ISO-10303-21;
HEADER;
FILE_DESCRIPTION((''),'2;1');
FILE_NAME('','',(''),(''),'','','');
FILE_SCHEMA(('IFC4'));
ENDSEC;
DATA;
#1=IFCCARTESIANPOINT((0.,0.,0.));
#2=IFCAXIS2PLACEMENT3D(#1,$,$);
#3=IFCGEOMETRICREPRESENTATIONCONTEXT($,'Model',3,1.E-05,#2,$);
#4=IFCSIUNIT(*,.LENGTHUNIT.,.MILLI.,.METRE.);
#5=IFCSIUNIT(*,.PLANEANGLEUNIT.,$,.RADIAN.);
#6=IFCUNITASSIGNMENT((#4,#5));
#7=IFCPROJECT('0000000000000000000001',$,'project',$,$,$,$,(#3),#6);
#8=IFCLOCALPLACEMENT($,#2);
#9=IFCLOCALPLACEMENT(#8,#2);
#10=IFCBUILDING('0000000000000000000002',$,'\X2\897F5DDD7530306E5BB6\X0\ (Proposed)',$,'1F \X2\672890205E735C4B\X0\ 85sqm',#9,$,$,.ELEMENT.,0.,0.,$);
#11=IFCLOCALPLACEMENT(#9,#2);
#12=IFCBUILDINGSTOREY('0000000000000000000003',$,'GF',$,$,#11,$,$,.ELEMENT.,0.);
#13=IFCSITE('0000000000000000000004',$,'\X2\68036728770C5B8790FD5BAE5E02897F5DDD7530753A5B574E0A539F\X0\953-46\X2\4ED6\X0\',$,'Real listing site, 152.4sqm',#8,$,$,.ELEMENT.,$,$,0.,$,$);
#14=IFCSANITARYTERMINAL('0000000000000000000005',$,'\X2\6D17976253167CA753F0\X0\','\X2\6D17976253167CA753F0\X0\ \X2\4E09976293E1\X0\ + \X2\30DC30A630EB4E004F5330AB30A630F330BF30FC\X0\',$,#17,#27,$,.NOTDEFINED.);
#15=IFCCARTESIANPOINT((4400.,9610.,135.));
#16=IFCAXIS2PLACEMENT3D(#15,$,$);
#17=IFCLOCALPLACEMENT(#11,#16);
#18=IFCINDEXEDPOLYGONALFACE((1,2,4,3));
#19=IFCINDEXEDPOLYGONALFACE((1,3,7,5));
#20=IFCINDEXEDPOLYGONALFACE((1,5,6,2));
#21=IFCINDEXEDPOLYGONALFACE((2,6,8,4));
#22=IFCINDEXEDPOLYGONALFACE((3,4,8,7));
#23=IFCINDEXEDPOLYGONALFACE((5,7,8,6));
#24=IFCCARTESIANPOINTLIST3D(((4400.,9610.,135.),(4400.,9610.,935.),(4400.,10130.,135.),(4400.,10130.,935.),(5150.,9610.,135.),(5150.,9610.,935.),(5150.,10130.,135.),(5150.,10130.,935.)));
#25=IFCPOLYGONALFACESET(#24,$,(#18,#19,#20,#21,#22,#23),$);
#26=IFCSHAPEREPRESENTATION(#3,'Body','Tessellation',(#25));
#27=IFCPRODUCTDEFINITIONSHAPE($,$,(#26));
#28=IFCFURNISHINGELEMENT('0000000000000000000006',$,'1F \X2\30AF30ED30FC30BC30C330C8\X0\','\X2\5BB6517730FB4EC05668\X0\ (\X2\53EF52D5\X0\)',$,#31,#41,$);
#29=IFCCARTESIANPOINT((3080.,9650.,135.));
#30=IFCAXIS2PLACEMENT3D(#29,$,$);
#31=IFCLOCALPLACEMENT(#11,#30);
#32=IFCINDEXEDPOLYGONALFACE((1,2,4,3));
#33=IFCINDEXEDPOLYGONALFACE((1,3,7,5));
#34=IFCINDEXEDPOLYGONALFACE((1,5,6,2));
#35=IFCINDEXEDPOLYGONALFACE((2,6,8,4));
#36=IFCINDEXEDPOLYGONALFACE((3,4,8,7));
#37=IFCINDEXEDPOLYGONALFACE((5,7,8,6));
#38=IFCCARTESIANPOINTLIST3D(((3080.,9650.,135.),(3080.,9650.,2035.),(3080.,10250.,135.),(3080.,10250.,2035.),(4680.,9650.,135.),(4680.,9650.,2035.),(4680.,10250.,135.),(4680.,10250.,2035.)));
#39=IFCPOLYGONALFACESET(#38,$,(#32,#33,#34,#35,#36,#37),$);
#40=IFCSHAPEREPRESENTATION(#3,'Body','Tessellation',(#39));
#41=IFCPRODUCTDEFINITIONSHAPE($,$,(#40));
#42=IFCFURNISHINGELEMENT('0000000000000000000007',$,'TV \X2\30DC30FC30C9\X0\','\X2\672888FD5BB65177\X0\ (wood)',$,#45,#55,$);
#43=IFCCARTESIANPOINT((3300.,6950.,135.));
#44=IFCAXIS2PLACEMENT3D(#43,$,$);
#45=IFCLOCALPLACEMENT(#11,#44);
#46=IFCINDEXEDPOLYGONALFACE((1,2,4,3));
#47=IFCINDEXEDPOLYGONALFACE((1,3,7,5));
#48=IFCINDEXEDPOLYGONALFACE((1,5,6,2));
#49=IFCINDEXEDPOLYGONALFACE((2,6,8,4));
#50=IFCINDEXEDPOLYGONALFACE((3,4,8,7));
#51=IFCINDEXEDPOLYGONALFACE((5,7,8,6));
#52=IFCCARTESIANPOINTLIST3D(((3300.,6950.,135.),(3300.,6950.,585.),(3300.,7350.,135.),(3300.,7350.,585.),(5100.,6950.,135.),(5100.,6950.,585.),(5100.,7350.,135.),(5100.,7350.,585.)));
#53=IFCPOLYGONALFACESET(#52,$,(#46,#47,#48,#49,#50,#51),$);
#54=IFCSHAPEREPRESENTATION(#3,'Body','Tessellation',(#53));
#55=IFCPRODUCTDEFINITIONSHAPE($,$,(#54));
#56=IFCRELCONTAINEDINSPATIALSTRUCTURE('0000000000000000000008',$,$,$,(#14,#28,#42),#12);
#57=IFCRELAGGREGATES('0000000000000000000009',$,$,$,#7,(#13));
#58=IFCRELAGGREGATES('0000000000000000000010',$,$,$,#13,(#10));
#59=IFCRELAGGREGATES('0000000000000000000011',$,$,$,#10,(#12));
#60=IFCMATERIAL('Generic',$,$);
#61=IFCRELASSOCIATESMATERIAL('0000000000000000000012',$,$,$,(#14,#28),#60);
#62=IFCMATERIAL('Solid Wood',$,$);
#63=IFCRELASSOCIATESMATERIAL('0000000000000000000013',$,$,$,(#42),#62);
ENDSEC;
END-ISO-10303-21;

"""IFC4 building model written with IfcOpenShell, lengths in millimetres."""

from ifc_helpers import new_model, si_unit, frame, frame_2d, origin, place, context, project, spatial, rectangle, extrude, material, element, save


model = new_model("IFC4")

# Units and contexts
model_context = context("Model", 3, precision=1e-05, world=origin())
ifc_project = project(units=[si_unit("LENGTHUNIT", "METRE", prefix="MILLI"), si_unit("PLANEANGLEUNIT", "RADIAN")], contexts=[model_context])

# Site, building, storey
site_placement = place(None, origin())
site = spatial("IfcSite", under=ifc_project, at=site_placement, Name="栃木県宇都宮市西川田町字上原953-46他", ObjectType="Real listing site, 152.4sqm", CompositionType="ELEMENT", RefElevation=0.0)
building_placement = place(site_placement, origin())
building = spatial("IfcBuilding", under=site, at=building_placement, Name="西川田の家 (Proposed)", ObjectType="1F 木造平屋 85sqm", CompositionType="ELEMENT", ElevationOfRefHeight=0.0, ElevationOfTerrain=0.0)
storey_placement = place(building_placement, origin())
storey = spatial("IfcBuildingStorey", under=building, at=storey_placement, Name="GF", CompositionType="ELEMENT", Elevation=0.0)

# Shared definitions
ifc_material_1 = material(Name="Solid Wood")

# Shared definitions
ifc_material_2 = material(Name="Generic")

# Sanitary terminal
sanitary_terminal_1_placement = place(storey_placement, frame((4400.0, 9610.0, 135.0)))
element("IfcSanitaryTerminal", 1, at=sanitary_terminal_1_placement, inside=storey, material=ifc_material_2, Name="洗面化粧台", Description="洗面化粧台 三面鏡 + ボウル一体カウンター", PredefinedType="NOTDEFINED", context=model_context, shape_type="SweptSolid", body=[
    extrude(rectangle(XDim=750.0, YDim=520.0, at=frame_2d((375.0, 260.0))), frame((4400.0, 9610.0, 135.0)), (0.0, 0.0, 1.0), 800.0),
])

# Furnishing elements
furnishing_1_placement = place(storey_placement, frame((3080.0, 9650.0, 135.0)))
element("IfcFurnishingElement", 2, at=furnishing_1_placement, inside=storey, material=ifc_material_2, Name="1F クローゼット", Description="家具・什器 (可動)", context=model_context, shape_type="SweptSolid", body=[
    extrude(rectangle(XDim=1600.0, YDim=600.0, at=frame_2d((800.0, 300.0))), frame((3080.0, 9650.0, 135.0)), (0.0, 0.0, 1.0), 1900.0),
])
furnishing_2_placement = place(storey_placement, frame((3300.0, 6950.0, 135.0)))
element("IfcFurnishingElement", 3, at=furnishing_2_placement, inside=storey, material=ifc_material_1, Name="TV ボード", Description="木製家具 (wood)", context=model_context, shape_type="SweptSolid", body=[
    extrude(rectangle(XDim=1800.0, YDim=400.0, at=frame_2d((900.0, 200.0))), frame((3300.0, 6950.0, 135.0)), (0.0, 0.0, 1.0), 450.0),
])

save(model, "model.ifc")
